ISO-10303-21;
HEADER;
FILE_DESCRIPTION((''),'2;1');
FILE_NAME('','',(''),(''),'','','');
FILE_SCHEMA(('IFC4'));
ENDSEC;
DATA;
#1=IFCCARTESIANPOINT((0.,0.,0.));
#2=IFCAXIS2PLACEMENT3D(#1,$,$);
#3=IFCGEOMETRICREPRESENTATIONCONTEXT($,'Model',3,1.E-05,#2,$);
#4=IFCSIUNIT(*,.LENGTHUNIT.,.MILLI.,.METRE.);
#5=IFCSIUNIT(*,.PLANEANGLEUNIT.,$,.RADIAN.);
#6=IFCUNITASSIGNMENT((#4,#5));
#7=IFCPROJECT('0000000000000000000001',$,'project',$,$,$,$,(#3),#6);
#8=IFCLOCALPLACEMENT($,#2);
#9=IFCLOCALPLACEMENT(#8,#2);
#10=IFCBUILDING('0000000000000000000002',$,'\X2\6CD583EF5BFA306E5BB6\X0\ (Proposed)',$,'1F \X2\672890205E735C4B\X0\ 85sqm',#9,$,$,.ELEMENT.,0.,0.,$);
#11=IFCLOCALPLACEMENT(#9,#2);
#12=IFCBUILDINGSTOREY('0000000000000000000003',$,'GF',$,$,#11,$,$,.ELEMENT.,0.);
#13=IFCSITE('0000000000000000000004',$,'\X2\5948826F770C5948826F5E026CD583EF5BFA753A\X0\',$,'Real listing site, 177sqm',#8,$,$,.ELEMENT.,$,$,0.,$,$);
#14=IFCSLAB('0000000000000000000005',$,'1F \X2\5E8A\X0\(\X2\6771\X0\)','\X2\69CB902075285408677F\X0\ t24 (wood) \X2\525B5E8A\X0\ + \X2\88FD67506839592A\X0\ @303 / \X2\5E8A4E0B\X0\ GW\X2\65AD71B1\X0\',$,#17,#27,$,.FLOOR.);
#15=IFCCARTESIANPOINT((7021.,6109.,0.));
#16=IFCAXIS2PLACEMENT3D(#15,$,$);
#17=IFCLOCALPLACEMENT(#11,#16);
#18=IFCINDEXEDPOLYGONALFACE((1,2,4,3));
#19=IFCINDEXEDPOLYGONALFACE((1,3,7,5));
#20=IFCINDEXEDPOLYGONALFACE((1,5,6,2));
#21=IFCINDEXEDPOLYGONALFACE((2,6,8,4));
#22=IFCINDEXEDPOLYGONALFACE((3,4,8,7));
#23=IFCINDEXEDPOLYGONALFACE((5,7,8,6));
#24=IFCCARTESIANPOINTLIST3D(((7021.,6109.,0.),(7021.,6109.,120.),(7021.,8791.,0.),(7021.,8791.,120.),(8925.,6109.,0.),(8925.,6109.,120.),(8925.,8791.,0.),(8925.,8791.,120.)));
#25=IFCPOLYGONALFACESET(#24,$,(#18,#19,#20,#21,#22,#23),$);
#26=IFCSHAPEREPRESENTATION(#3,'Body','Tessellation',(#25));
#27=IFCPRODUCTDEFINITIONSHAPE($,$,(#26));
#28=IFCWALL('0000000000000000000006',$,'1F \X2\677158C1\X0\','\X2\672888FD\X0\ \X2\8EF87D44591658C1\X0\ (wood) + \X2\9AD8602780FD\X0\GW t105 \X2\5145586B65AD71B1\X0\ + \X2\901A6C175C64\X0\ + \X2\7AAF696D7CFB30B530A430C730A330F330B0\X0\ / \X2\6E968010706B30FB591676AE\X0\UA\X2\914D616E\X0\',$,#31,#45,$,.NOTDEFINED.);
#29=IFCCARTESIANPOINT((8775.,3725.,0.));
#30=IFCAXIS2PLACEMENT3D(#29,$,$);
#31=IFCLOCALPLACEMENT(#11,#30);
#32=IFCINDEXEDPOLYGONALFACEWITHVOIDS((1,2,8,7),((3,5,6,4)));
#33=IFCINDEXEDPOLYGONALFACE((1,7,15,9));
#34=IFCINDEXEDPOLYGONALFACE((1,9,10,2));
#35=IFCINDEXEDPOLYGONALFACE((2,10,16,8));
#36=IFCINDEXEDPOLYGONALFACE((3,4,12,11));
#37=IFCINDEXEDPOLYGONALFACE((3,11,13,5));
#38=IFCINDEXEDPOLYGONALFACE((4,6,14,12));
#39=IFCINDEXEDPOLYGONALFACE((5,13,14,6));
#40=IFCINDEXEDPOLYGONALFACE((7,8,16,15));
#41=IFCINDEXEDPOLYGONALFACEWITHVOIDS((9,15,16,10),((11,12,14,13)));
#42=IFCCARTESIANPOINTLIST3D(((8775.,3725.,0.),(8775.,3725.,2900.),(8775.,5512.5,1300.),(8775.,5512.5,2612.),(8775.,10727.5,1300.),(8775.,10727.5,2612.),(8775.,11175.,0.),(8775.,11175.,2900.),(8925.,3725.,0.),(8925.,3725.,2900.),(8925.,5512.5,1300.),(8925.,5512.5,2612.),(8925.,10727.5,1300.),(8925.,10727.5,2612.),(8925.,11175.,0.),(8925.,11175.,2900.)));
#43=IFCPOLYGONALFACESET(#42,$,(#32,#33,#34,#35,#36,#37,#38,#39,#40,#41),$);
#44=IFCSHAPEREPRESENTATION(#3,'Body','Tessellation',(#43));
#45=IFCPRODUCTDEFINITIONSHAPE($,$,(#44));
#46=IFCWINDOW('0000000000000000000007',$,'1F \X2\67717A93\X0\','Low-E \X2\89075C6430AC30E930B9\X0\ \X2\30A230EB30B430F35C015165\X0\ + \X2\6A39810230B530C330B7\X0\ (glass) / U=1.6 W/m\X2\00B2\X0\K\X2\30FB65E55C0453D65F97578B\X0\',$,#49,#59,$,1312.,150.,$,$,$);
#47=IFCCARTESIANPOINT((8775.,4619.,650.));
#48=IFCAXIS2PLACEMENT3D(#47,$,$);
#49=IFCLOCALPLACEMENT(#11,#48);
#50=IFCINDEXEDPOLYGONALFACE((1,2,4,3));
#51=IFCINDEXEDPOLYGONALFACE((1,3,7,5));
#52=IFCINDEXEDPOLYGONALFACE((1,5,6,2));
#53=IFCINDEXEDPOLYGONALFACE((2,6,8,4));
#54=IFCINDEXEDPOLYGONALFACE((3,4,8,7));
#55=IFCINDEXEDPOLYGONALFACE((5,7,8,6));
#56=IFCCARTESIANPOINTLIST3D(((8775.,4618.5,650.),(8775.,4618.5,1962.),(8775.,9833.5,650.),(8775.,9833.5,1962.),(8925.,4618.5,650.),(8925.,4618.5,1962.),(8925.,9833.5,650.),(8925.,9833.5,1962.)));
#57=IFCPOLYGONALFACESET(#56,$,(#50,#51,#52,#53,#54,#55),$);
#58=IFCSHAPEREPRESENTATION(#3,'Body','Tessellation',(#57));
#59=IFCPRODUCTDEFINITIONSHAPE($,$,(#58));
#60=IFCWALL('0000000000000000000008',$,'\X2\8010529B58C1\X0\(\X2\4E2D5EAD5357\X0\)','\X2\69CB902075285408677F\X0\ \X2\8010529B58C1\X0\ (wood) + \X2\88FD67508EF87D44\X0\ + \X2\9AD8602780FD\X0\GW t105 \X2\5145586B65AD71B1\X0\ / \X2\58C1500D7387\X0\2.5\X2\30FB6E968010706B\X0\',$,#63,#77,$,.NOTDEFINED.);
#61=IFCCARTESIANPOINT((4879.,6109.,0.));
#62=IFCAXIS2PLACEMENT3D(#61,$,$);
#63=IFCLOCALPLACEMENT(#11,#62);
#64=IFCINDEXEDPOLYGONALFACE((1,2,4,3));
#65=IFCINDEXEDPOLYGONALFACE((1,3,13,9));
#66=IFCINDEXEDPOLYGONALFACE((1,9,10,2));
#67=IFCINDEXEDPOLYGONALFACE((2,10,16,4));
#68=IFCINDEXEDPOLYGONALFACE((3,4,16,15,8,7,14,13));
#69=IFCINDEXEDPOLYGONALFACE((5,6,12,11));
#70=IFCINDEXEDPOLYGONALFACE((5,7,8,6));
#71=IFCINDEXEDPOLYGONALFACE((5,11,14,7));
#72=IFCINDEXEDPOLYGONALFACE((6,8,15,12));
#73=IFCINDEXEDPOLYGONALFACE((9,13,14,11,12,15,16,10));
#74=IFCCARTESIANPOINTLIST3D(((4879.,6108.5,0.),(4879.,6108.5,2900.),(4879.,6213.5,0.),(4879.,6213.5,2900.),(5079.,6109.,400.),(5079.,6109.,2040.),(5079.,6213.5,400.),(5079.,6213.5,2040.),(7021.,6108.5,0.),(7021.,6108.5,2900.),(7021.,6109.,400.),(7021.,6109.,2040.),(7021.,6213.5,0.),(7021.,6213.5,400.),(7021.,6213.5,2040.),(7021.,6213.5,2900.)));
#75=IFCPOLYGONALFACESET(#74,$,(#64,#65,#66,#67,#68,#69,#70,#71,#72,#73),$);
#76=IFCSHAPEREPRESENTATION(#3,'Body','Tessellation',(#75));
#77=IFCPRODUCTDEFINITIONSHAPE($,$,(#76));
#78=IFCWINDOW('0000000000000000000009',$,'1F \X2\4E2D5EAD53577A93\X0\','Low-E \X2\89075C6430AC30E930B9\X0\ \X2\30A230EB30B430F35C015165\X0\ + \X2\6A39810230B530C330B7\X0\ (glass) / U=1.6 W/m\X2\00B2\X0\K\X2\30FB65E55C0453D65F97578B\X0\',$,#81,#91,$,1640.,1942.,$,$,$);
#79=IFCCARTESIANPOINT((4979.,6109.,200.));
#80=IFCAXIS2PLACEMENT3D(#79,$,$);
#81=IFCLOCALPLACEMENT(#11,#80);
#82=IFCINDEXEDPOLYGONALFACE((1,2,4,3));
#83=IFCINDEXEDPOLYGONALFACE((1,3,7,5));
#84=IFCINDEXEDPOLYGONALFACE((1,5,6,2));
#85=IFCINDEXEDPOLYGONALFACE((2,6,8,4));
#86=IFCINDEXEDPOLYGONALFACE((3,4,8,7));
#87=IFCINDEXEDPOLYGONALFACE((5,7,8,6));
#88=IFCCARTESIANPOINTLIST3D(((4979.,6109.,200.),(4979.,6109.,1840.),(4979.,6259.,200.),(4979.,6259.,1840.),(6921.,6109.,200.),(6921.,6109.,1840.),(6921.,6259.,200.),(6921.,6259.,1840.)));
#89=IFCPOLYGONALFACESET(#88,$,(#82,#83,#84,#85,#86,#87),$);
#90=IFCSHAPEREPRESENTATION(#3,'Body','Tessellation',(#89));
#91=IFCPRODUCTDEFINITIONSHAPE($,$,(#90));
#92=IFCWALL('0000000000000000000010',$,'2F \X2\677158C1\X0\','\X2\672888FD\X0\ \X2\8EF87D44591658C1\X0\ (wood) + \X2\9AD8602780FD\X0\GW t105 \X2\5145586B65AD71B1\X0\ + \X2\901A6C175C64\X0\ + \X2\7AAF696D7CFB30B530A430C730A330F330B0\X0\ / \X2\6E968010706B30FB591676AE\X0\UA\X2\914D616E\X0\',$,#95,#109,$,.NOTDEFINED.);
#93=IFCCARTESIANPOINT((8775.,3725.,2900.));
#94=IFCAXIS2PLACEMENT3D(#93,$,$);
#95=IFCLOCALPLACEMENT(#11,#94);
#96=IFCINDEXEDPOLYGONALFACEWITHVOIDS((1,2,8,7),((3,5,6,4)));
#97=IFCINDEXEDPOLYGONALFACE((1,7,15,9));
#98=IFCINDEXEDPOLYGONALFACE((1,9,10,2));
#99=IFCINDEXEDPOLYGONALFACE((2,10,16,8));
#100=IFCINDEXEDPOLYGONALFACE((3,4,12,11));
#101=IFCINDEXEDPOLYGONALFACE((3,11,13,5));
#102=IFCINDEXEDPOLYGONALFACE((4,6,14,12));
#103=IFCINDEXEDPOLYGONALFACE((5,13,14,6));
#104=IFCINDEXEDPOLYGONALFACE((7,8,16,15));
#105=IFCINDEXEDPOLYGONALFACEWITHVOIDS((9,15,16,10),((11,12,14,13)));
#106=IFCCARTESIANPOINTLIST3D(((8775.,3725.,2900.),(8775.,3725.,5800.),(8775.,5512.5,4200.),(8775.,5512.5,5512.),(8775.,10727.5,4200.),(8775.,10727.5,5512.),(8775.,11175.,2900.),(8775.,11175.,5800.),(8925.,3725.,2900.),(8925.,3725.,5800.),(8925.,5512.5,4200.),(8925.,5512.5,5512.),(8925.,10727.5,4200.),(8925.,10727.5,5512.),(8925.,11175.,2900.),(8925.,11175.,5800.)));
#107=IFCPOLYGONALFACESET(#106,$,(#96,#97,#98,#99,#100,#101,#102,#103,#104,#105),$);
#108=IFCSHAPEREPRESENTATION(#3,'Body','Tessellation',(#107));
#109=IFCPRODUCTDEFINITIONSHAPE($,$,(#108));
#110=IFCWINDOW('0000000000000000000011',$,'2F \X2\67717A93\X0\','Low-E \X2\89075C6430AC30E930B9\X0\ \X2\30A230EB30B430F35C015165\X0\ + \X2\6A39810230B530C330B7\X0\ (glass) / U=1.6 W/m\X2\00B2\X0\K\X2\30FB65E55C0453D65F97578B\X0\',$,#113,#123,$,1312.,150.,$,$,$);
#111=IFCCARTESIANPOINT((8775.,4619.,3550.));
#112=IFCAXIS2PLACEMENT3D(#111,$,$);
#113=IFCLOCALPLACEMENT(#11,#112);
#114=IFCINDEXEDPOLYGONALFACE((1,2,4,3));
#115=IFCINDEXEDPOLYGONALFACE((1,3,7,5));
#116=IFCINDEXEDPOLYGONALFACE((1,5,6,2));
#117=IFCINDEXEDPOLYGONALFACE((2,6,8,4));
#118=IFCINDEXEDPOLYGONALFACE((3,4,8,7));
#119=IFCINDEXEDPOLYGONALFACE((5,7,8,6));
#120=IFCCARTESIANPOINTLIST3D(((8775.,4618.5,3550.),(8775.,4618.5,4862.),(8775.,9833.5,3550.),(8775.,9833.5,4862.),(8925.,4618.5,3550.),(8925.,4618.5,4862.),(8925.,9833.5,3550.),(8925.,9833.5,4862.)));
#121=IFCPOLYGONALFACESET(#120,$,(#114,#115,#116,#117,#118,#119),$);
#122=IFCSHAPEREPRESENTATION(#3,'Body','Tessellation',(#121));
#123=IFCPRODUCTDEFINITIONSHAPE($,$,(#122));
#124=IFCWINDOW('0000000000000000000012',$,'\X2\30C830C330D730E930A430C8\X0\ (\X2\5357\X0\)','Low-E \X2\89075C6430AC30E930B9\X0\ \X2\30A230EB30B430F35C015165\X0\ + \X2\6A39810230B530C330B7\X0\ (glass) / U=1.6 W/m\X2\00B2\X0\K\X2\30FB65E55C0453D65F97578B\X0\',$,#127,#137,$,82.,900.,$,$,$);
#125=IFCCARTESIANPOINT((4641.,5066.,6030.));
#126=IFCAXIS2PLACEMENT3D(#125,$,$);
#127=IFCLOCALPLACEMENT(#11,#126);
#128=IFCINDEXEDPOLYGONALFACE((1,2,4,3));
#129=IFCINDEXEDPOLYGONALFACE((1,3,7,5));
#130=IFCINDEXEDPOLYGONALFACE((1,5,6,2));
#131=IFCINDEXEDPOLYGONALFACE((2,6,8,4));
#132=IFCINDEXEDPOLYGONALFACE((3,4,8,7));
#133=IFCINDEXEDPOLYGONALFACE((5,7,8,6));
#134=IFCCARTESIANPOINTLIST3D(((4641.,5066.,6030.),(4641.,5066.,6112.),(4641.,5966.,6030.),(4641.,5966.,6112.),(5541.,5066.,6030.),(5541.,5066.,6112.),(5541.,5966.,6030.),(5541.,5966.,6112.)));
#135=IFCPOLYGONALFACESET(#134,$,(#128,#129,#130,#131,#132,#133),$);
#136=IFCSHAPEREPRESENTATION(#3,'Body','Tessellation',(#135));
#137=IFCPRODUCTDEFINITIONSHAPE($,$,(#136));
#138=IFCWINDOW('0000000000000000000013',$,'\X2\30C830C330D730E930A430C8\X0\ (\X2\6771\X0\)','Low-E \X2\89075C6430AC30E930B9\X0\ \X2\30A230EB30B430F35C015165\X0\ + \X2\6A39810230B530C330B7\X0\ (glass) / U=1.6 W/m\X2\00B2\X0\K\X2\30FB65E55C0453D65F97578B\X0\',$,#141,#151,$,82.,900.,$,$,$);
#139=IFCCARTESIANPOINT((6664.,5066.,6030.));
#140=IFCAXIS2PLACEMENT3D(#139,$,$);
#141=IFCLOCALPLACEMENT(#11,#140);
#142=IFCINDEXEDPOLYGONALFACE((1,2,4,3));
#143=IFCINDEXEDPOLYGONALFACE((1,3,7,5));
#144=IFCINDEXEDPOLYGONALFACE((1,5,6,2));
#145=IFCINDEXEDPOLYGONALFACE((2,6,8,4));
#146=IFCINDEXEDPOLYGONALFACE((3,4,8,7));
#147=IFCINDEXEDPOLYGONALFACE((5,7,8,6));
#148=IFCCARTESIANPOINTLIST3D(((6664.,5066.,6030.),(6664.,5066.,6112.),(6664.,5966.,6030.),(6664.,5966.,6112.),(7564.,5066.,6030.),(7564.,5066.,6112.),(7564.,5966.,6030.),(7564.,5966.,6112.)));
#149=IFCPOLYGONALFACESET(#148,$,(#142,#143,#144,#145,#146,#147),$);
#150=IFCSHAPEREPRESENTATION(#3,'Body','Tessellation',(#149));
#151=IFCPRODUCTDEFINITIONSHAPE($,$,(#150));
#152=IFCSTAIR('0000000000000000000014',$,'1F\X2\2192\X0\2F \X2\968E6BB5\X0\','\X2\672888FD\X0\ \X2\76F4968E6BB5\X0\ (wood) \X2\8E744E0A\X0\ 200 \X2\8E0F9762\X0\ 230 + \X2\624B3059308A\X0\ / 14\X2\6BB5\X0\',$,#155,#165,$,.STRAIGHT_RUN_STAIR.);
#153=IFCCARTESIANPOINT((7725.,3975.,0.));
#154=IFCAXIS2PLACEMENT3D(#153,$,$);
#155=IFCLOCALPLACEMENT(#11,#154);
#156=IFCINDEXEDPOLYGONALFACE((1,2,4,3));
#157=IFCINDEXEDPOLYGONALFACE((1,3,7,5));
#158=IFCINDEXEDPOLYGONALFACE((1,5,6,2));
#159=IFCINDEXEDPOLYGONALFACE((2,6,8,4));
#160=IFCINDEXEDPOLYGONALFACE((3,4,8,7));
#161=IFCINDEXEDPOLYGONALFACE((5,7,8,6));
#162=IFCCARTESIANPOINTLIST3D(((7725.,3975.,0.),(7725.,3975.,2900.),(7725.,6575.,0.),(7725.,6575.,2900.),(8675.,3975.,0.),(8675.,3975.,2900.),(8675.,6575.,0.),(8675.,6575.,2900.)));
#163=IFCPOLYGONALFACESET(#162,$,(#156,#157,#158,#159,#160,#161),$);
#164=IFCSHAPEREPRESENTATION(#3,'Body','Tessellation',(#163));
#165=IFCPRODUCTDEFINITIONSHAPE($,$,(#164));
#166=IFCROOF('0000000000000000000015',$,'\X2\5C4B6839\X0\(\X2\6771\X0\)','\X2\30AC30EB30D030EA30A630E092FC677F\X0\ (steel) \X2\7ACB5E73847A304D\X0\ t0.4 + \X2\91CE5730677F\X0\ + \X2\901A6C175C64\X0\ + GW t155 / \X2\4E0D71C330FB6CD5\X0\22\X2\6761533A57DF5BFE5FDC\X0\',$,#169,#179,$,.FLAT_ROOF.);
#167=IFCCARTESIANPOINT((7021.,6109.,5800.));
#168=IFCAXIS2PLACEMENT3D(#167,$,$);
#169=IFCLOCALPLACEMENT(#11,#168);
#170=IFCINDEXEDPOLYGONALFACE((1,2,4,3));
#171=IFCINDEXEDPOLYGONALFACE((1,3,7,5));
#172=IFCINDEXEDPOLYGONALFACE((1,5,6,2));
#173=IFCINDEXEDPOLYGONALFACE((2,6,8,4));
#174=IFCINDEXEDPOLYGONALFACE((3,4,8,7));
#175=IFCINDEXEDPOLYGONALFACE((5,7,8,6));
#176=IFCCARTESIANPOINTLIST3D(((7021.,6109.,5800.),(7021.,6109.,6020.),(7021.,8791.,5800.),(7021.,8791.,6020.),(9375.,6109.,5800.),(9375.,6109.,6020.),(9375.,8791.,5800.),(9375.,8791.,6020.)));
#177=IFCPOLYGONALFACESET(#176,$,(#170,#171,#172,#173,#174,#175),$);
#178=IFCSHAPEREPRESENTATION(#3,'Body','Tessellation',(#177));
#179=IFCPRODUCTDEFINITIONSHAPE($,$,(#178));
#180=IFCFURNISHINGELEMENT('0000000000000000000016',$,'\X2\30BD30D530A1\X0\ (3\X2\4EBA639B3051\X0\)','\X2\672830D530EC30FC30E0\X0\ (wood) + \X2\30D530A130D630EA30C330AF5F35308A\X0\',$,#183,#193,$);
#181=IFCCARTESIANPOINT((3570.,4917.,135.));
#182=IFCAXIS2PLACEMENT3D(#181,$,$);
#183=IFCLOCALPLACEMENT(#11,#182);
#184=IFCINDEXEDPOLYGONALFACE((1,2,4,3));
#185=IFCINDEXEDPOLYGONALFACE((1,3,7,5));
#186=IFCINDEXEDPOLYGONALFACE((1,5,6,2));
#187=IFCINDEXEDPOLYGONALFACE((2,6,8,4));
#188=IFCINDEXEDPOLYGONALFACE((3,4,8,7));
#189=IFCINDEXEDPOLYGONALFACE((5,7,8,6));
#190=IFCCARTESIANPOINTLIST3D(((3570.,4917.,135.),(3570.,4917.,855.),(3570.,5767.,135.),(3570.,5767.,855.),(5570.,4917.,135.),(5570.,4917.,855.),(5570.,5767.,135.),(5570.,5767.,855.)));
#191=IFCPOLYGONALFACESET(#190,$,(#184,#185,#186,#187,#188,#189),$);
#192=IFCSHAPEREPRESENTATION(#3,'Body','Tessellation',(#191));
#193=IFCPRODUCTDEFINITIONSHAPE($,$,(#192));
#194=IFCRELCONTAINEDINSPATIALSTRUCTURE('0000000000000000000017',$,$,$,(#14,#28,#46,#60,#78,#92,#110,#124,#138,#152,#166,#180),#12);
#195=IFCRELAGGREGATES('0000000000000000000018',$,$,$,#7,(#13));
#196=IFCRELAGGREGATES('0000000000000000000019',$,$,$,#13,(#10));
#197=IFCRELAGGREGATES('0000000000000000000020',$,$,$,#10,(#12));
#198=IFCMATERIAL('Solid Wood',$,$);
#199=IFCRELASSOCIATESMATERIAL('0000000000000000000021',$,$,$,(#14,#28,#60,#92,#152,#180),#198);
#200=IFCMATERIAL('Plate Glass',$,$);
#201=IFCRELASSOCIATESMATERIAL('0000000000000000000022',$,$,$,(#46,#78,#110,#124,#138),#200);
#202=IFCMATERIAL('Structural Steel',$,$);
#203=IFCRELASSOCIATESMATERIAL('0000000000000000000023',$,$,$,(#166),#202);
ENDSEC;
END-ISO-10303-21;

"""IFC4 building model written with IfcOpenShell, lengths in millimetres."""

from ifc_helpers import new_model, si_unit, frame, frame_2d, origin, place, context, project, spatial, rectangle, extrude, material, element, fill, save


model = new_model("IFC4")

# Units and contexts
model_context = context("Model", 3, precision=1e-05, world=origin())
ifc_project = project(units=[si_unit("LENGTHUNIT", "METRE", prefix="MILLI"), si_unit("PLANEANGLEUNIT", "RADIAN")], contexts=[model_context])

# Site, building, storey
site_placement = place(None, origin())
site = spatial("IfcSite", under=ifc_project, at=site_placement, Name="奈良県奈良市法華寺町", ObjectType="Real listing site, 177sqm", CompositionType="ELEMENT", RefElevation=0.0)
building_placement = place(site_placement, origin())
building = spatial("IfcBuilding", under=site, at=building_placement, Name="法華寺の家 (Proposed)", ObjectType="1F 木造平屋 85sqm", CompositionType="ELEMENT", ElevationOfRefHeight=0.0, ElevationOfTerrain=0.0)
storey_placement = place(building_placement, origin())
storey = spatial("IfcBuildingStorey", under=building, at=storey_placement, Name="GF", CompositionType="ELEMENT", Elevation=0.0)

# Slab
ifc_material_1 = material(Name="Solid Wood")
slab_placement = place(storey_placement, frame((7021.0, 6109.0, 0.0)))
element("IfcSlab", 1, at=slab_placement, inside=storey, material=ifc_material_1, Name="1F 床(東)", Description="構造用合板 t24 (wood) 剛床 + 製材根太 @303 / 床下 GW断熱", PredefinedType="FLOOR", context=model_context, shape_type="SweptSolid", body=[
    extrude(rectangle(XDim=1904.0, YDim=2682.0, at=frame_2d((952.0, 1341.0))), frame((7021.0, 6109.0, 0.0)), (0.0, 0.0, 1.0), 120.0),
])

# Walls, openings, windows
wall_1_placement = place(storey_placement, frame((8775.0, 3725.0, 0.0)))
wall_1 = element("IfcWall", 2, at=wall_1_placement, inside=storey, material=ifc_material_1, Name="1F 東壁", Description="木製 軸組外壁 (wood) + 高性能GW t105 充填断熱 + 通気層 + 窯業系サイディング / 準耐火・外皮UA配慮", PredefinedType="NOTDEFINED", context=model_context, shape_type="SweptSolid", body=[
    extrude(rectangle(XDim=150.0, YDim=7450.0, at=frame_2d((75.0, 3725.0))), frame((8775.0, 3725.0, 0.0)), (0.0, 0.0, 1.0), 2900.0),
])
opening_1_placement = place(storey_placement, frame((8775.0, 4619.0, 650.0)))
opening_1 = element("IfcOpeningElement", 3, at=opening_1_placement, cuts=wall_1, PredefinedType="NOTDEFINED", context=model_context, shape_type="SweptSolid", body=[
    extrude(rectangle(XDim=150.0, YDim=5215.0, at=frame_2d((75.0, 2607.0))), frame((8775.0, 4619.0, 650.0)), (0.0, 0.0, 1.0), 1312.0),
])
ifc_material_2 = material(Name="Plate Glass")
window_1_placement = place(storey_placement, frame((8775.0, 4619.0, 650.0)))
window_1 = element("IfcWindow", 4, at=window_1_placement, inside=storey, material=ifc_material_2, Name="1F 東窓", Description="Low-E 複層ガラス アルゴン封入 + 樹脂サッシ (glass) / U=1.6 W/m²K・日射取得型", OverallHeight=1312.0, OverallWidth=150.0, context=model_context, shape_type="SweptSolid", body=[
    extrude(rectangle(XDim=150.0, YDim=5215.0, at=frame_2d((75.0, 2607.0))), frame((8775.0, 4619.0, 650.0)), (0.0, 0.0, 1.0), 1312.0),
])
fill(opening_1, window_1)
wall_2_placement = place(storey_placement, frame((4879.0, 6109.0, 0.0)))
wall_2 = element("IfcWall", 5, at=wall_2_placement, inside=storey, material=ifc_material_1, Name="耐力壁(中庭南)", Description="構造用合板 耐力壁 (wood) + 製材軸組 + 高性能GW t105 充填断熱 / 壁倍率2.5・準耐火", PredefinedType="NOTDEFINED", context=model_context, shape_type="SweptSolid", body=[
    extrude(rectangle(XDim=2142.0, YDim=105.0, at=frame_2d((1071.0, 52.0))), frame((4879.0, 6109.0, 0.0)), (0.0, 0.0, 1.0), 2900.0),
])
opening_2_placement = place(storey_placement, frame((4979.0, 6109.0, 200.0)))
opening_2 = element("IfcOpeningElement", 6, at=opening_2_placement, cuts=wall_2, PredefinedType="NOTDEFINED", context=model_context, shape_type="SweptSolid", body=[
    extrude(rectangle(XDim=1942.0, YDim=150.0, at=frame_2d((971.0, 75.0))), frame((4979.0, 6109.0, 200.0)), (0.0, 0.0, 1.0), 1640.0),
])
window_2_placement = place(storey_placement, frame((4979.0, 6109.0, 200.0)))
window_2 = element("IfcWindow", 7, at=window_2_placement, inside=storey, material=ifc_material_2, Name="1F 中庭南窓", Description="Low-E 複層ガラス アルゴン封入 + 樹脂サッシ (glass) / U=1.6 W/m²K・日射取得型", OverallHeight=1640.0, OverallWidth=1942.0, context=model_context, shape_type="SweptSolid", body=[
    extrude(rectangle(XDim=1942.0, YDim=150.0, at=frame_2d((971.0, 75.0))), frame((4979.0, 6109.0, 200.0)), (0.0, 0.0, 1.0), 1640.0),
])
fill(opening_2, window_2)

# Wall, opening, window
wall_3_placement = place(storey_placement, frame((8775.0, 3725.0, 2900.0)))
wall_3 = element("IfcWall", 8, at=wall_3_placement, inside=storey, material=ifc_material_1, Name="2F 東壁", Description="木製 軸組外壁 (wood) + 高性能GW t105 充填断熱 + 通気層 + 窯業系サイディング / 準耐火・外皮UA配慮", PredefinedType="NOTDEFINED", context=model_context, shape_type="SweptSolid", body=[
    extrude(rectangle(XDim=150.0, YDim=7450.0, at=frame_2d((75.0, 3725.0))), frame((8775.0, 3725.0, 2900.0)), (0.0, 0.0, 1.0), 2900.0),
])
opening_3_placement = place(storey_placement, frame((8775.0, 4619.0, 3550.0)))
opening_3 = element("IfcOpeningElement", 9, at=opening_3_placement, cuts=wall_3, PredefinedType="NOTDEFINED", context=model_context, shape_type="SweptSolid", body=[
    extrude(rectangle(XDim=150.0, YDim=5215.0, at=frame_2d((75.0, 2607.0))), frame((8775.0, 4619.0, 3550.0)), (0.0, 0.0, 1.0), 1312.0),
])
window_3_placement = place(storey_placement, frame((8775.0, 4619.0, 3550.0)))
window_3 = element("IfcWindow", 10, at=window_3_placement, inside=storey, material=ifc_material_2, Name="2F 東窓", Description="Low-E 複層ガラス アルゴン封入 + 樹脂サッシ (glass) / U=1.6 W/m²K・日射取得型", OverallHeight=1312.0, OverallWidth=150.0, context=model_context, shape_type="SweptSolid", body=[
    extrude(rectangle(XDim=150.0, YDim=5215.0, at=frame_2d((75.0, 2607.0))), frame((8775.0, 4619.0, 3550.0)), (0.0, 0.0, 1.0), 1312.0),
])
fill(opening_3, window_3)

# Windows
window_4_placement = place(storey_placement, frame((4641.0, 5066.0, 6030.0)))
element("IfcWindow", 11, at=window_4_placement, inside=storey, material=ifc_material_2, Name="トップライト (南)", Description="Low-E 複層ガラス アルゴン封入 + 樹脂サッシ (glass) / U=1.6 W/m²K・日射取得型", OverallHeight=82.0, OverallWidth=900.0, context=model_context, shape_type="SweptSolid", body=[
    extrude(rectangle(XDim=900.0, YDim=900.0, at=frame_2d((450.0, 450.0))), frame((4641.0, 5066.0, 6030.0)), (0.0, 0.0, 1.0), 82.0),
])
window_5_placement = place(storey_placement, frame((6664.0, 5066.0, 6030.0)))
element("IfcWindow", 12, at=window_5_placement, inside=storey, material=ifc_material_2, Name="トップライト (東)", Description="Low-E 複層ガラス アルゴン封入 + 樹脂サッシ (glass) / U=1.6 W/m²K・日射取得型", OverallHeight=82.0, OverallWidth=900.0, context=model_context, shape_type="SweptSolid", body=[
    extrude(rectangle(XDim=900.0, YDim=900.0, at=frame_2d((450.0, 450.0))), frame((6664.0, 5066.0, 6030.0)), (0.0, 0.0, 1.0), 82.0),
])

# Stair
stair_placement = place(storey_placement, frame((7725.0, 3975.0, 0.0)))
element("IfcStair", 13, at=stair_placement, inside=storey, material=ifc_material_1, Name="1F→2F 階段", Description="木製 直階段 (wood) 蹴上 200 踏面 230 + 手すり / 14段", PredefinedType="STRAIGHT_RUN_STAIR", context=model_context, shape_type="SweptSolid", body=[
    extrude(rectangle(XDim=950.0, YDim=2600.0, at=frame_2d((475.0, 1300.0))), frame((7725.0, 3975.0, 0.0)), (0.0, 0.0, 1.0), 2900.0),
])

# Roof
ifc_material_3 = material(Name="Structural Steel")
roof_placement = place(storey_placement, frame((7021.0, 6109.0, 5800.0)))
element("IfcRoof", 14, at=roof_placement, inside=storey, material=ifc_material_3, Name="屋根(東)", Description="ガルバリウム鋼板 (steel) 立平葺き t0.4 + 野地板 + 通気層 + GW t155 / 不燃・法22条区域対応", PredefinedType="FLAT_ROOF", context=model_context, shape_type="SweptSolid", body=[
    extrude(rectangle(XDim=2354.0, YDim=2682.0, at=frame_2d((1177.0, 1341.0))), frame((7021.0, 6109.0, 5800.0)), (0.0, 0.0, 1.0), 220.0),
])

# Furnishing element
furnishing_1_placement = place(storey_placement, frame((3570.0, 4917.0, 135.0)))
element("IfcFurnishingElement", 15, at=furnishing_1_placement, inside=storey, material=ifc_material_1, Name="ソファ (3人掛け)", Description="木フレーム (wood) + ファブリック張り", context=model_context, shape_type="SweptSolid", body=[
    extrude(rectangle(XDim=2000.0, YDim=850.0, at=frame_2d((1000.0, 425.0))), frame((3570.0, 4917.0, 135.0)), (0.0, 0.0, 1.0), 720.0),
])

save(model, "model.ifc")
